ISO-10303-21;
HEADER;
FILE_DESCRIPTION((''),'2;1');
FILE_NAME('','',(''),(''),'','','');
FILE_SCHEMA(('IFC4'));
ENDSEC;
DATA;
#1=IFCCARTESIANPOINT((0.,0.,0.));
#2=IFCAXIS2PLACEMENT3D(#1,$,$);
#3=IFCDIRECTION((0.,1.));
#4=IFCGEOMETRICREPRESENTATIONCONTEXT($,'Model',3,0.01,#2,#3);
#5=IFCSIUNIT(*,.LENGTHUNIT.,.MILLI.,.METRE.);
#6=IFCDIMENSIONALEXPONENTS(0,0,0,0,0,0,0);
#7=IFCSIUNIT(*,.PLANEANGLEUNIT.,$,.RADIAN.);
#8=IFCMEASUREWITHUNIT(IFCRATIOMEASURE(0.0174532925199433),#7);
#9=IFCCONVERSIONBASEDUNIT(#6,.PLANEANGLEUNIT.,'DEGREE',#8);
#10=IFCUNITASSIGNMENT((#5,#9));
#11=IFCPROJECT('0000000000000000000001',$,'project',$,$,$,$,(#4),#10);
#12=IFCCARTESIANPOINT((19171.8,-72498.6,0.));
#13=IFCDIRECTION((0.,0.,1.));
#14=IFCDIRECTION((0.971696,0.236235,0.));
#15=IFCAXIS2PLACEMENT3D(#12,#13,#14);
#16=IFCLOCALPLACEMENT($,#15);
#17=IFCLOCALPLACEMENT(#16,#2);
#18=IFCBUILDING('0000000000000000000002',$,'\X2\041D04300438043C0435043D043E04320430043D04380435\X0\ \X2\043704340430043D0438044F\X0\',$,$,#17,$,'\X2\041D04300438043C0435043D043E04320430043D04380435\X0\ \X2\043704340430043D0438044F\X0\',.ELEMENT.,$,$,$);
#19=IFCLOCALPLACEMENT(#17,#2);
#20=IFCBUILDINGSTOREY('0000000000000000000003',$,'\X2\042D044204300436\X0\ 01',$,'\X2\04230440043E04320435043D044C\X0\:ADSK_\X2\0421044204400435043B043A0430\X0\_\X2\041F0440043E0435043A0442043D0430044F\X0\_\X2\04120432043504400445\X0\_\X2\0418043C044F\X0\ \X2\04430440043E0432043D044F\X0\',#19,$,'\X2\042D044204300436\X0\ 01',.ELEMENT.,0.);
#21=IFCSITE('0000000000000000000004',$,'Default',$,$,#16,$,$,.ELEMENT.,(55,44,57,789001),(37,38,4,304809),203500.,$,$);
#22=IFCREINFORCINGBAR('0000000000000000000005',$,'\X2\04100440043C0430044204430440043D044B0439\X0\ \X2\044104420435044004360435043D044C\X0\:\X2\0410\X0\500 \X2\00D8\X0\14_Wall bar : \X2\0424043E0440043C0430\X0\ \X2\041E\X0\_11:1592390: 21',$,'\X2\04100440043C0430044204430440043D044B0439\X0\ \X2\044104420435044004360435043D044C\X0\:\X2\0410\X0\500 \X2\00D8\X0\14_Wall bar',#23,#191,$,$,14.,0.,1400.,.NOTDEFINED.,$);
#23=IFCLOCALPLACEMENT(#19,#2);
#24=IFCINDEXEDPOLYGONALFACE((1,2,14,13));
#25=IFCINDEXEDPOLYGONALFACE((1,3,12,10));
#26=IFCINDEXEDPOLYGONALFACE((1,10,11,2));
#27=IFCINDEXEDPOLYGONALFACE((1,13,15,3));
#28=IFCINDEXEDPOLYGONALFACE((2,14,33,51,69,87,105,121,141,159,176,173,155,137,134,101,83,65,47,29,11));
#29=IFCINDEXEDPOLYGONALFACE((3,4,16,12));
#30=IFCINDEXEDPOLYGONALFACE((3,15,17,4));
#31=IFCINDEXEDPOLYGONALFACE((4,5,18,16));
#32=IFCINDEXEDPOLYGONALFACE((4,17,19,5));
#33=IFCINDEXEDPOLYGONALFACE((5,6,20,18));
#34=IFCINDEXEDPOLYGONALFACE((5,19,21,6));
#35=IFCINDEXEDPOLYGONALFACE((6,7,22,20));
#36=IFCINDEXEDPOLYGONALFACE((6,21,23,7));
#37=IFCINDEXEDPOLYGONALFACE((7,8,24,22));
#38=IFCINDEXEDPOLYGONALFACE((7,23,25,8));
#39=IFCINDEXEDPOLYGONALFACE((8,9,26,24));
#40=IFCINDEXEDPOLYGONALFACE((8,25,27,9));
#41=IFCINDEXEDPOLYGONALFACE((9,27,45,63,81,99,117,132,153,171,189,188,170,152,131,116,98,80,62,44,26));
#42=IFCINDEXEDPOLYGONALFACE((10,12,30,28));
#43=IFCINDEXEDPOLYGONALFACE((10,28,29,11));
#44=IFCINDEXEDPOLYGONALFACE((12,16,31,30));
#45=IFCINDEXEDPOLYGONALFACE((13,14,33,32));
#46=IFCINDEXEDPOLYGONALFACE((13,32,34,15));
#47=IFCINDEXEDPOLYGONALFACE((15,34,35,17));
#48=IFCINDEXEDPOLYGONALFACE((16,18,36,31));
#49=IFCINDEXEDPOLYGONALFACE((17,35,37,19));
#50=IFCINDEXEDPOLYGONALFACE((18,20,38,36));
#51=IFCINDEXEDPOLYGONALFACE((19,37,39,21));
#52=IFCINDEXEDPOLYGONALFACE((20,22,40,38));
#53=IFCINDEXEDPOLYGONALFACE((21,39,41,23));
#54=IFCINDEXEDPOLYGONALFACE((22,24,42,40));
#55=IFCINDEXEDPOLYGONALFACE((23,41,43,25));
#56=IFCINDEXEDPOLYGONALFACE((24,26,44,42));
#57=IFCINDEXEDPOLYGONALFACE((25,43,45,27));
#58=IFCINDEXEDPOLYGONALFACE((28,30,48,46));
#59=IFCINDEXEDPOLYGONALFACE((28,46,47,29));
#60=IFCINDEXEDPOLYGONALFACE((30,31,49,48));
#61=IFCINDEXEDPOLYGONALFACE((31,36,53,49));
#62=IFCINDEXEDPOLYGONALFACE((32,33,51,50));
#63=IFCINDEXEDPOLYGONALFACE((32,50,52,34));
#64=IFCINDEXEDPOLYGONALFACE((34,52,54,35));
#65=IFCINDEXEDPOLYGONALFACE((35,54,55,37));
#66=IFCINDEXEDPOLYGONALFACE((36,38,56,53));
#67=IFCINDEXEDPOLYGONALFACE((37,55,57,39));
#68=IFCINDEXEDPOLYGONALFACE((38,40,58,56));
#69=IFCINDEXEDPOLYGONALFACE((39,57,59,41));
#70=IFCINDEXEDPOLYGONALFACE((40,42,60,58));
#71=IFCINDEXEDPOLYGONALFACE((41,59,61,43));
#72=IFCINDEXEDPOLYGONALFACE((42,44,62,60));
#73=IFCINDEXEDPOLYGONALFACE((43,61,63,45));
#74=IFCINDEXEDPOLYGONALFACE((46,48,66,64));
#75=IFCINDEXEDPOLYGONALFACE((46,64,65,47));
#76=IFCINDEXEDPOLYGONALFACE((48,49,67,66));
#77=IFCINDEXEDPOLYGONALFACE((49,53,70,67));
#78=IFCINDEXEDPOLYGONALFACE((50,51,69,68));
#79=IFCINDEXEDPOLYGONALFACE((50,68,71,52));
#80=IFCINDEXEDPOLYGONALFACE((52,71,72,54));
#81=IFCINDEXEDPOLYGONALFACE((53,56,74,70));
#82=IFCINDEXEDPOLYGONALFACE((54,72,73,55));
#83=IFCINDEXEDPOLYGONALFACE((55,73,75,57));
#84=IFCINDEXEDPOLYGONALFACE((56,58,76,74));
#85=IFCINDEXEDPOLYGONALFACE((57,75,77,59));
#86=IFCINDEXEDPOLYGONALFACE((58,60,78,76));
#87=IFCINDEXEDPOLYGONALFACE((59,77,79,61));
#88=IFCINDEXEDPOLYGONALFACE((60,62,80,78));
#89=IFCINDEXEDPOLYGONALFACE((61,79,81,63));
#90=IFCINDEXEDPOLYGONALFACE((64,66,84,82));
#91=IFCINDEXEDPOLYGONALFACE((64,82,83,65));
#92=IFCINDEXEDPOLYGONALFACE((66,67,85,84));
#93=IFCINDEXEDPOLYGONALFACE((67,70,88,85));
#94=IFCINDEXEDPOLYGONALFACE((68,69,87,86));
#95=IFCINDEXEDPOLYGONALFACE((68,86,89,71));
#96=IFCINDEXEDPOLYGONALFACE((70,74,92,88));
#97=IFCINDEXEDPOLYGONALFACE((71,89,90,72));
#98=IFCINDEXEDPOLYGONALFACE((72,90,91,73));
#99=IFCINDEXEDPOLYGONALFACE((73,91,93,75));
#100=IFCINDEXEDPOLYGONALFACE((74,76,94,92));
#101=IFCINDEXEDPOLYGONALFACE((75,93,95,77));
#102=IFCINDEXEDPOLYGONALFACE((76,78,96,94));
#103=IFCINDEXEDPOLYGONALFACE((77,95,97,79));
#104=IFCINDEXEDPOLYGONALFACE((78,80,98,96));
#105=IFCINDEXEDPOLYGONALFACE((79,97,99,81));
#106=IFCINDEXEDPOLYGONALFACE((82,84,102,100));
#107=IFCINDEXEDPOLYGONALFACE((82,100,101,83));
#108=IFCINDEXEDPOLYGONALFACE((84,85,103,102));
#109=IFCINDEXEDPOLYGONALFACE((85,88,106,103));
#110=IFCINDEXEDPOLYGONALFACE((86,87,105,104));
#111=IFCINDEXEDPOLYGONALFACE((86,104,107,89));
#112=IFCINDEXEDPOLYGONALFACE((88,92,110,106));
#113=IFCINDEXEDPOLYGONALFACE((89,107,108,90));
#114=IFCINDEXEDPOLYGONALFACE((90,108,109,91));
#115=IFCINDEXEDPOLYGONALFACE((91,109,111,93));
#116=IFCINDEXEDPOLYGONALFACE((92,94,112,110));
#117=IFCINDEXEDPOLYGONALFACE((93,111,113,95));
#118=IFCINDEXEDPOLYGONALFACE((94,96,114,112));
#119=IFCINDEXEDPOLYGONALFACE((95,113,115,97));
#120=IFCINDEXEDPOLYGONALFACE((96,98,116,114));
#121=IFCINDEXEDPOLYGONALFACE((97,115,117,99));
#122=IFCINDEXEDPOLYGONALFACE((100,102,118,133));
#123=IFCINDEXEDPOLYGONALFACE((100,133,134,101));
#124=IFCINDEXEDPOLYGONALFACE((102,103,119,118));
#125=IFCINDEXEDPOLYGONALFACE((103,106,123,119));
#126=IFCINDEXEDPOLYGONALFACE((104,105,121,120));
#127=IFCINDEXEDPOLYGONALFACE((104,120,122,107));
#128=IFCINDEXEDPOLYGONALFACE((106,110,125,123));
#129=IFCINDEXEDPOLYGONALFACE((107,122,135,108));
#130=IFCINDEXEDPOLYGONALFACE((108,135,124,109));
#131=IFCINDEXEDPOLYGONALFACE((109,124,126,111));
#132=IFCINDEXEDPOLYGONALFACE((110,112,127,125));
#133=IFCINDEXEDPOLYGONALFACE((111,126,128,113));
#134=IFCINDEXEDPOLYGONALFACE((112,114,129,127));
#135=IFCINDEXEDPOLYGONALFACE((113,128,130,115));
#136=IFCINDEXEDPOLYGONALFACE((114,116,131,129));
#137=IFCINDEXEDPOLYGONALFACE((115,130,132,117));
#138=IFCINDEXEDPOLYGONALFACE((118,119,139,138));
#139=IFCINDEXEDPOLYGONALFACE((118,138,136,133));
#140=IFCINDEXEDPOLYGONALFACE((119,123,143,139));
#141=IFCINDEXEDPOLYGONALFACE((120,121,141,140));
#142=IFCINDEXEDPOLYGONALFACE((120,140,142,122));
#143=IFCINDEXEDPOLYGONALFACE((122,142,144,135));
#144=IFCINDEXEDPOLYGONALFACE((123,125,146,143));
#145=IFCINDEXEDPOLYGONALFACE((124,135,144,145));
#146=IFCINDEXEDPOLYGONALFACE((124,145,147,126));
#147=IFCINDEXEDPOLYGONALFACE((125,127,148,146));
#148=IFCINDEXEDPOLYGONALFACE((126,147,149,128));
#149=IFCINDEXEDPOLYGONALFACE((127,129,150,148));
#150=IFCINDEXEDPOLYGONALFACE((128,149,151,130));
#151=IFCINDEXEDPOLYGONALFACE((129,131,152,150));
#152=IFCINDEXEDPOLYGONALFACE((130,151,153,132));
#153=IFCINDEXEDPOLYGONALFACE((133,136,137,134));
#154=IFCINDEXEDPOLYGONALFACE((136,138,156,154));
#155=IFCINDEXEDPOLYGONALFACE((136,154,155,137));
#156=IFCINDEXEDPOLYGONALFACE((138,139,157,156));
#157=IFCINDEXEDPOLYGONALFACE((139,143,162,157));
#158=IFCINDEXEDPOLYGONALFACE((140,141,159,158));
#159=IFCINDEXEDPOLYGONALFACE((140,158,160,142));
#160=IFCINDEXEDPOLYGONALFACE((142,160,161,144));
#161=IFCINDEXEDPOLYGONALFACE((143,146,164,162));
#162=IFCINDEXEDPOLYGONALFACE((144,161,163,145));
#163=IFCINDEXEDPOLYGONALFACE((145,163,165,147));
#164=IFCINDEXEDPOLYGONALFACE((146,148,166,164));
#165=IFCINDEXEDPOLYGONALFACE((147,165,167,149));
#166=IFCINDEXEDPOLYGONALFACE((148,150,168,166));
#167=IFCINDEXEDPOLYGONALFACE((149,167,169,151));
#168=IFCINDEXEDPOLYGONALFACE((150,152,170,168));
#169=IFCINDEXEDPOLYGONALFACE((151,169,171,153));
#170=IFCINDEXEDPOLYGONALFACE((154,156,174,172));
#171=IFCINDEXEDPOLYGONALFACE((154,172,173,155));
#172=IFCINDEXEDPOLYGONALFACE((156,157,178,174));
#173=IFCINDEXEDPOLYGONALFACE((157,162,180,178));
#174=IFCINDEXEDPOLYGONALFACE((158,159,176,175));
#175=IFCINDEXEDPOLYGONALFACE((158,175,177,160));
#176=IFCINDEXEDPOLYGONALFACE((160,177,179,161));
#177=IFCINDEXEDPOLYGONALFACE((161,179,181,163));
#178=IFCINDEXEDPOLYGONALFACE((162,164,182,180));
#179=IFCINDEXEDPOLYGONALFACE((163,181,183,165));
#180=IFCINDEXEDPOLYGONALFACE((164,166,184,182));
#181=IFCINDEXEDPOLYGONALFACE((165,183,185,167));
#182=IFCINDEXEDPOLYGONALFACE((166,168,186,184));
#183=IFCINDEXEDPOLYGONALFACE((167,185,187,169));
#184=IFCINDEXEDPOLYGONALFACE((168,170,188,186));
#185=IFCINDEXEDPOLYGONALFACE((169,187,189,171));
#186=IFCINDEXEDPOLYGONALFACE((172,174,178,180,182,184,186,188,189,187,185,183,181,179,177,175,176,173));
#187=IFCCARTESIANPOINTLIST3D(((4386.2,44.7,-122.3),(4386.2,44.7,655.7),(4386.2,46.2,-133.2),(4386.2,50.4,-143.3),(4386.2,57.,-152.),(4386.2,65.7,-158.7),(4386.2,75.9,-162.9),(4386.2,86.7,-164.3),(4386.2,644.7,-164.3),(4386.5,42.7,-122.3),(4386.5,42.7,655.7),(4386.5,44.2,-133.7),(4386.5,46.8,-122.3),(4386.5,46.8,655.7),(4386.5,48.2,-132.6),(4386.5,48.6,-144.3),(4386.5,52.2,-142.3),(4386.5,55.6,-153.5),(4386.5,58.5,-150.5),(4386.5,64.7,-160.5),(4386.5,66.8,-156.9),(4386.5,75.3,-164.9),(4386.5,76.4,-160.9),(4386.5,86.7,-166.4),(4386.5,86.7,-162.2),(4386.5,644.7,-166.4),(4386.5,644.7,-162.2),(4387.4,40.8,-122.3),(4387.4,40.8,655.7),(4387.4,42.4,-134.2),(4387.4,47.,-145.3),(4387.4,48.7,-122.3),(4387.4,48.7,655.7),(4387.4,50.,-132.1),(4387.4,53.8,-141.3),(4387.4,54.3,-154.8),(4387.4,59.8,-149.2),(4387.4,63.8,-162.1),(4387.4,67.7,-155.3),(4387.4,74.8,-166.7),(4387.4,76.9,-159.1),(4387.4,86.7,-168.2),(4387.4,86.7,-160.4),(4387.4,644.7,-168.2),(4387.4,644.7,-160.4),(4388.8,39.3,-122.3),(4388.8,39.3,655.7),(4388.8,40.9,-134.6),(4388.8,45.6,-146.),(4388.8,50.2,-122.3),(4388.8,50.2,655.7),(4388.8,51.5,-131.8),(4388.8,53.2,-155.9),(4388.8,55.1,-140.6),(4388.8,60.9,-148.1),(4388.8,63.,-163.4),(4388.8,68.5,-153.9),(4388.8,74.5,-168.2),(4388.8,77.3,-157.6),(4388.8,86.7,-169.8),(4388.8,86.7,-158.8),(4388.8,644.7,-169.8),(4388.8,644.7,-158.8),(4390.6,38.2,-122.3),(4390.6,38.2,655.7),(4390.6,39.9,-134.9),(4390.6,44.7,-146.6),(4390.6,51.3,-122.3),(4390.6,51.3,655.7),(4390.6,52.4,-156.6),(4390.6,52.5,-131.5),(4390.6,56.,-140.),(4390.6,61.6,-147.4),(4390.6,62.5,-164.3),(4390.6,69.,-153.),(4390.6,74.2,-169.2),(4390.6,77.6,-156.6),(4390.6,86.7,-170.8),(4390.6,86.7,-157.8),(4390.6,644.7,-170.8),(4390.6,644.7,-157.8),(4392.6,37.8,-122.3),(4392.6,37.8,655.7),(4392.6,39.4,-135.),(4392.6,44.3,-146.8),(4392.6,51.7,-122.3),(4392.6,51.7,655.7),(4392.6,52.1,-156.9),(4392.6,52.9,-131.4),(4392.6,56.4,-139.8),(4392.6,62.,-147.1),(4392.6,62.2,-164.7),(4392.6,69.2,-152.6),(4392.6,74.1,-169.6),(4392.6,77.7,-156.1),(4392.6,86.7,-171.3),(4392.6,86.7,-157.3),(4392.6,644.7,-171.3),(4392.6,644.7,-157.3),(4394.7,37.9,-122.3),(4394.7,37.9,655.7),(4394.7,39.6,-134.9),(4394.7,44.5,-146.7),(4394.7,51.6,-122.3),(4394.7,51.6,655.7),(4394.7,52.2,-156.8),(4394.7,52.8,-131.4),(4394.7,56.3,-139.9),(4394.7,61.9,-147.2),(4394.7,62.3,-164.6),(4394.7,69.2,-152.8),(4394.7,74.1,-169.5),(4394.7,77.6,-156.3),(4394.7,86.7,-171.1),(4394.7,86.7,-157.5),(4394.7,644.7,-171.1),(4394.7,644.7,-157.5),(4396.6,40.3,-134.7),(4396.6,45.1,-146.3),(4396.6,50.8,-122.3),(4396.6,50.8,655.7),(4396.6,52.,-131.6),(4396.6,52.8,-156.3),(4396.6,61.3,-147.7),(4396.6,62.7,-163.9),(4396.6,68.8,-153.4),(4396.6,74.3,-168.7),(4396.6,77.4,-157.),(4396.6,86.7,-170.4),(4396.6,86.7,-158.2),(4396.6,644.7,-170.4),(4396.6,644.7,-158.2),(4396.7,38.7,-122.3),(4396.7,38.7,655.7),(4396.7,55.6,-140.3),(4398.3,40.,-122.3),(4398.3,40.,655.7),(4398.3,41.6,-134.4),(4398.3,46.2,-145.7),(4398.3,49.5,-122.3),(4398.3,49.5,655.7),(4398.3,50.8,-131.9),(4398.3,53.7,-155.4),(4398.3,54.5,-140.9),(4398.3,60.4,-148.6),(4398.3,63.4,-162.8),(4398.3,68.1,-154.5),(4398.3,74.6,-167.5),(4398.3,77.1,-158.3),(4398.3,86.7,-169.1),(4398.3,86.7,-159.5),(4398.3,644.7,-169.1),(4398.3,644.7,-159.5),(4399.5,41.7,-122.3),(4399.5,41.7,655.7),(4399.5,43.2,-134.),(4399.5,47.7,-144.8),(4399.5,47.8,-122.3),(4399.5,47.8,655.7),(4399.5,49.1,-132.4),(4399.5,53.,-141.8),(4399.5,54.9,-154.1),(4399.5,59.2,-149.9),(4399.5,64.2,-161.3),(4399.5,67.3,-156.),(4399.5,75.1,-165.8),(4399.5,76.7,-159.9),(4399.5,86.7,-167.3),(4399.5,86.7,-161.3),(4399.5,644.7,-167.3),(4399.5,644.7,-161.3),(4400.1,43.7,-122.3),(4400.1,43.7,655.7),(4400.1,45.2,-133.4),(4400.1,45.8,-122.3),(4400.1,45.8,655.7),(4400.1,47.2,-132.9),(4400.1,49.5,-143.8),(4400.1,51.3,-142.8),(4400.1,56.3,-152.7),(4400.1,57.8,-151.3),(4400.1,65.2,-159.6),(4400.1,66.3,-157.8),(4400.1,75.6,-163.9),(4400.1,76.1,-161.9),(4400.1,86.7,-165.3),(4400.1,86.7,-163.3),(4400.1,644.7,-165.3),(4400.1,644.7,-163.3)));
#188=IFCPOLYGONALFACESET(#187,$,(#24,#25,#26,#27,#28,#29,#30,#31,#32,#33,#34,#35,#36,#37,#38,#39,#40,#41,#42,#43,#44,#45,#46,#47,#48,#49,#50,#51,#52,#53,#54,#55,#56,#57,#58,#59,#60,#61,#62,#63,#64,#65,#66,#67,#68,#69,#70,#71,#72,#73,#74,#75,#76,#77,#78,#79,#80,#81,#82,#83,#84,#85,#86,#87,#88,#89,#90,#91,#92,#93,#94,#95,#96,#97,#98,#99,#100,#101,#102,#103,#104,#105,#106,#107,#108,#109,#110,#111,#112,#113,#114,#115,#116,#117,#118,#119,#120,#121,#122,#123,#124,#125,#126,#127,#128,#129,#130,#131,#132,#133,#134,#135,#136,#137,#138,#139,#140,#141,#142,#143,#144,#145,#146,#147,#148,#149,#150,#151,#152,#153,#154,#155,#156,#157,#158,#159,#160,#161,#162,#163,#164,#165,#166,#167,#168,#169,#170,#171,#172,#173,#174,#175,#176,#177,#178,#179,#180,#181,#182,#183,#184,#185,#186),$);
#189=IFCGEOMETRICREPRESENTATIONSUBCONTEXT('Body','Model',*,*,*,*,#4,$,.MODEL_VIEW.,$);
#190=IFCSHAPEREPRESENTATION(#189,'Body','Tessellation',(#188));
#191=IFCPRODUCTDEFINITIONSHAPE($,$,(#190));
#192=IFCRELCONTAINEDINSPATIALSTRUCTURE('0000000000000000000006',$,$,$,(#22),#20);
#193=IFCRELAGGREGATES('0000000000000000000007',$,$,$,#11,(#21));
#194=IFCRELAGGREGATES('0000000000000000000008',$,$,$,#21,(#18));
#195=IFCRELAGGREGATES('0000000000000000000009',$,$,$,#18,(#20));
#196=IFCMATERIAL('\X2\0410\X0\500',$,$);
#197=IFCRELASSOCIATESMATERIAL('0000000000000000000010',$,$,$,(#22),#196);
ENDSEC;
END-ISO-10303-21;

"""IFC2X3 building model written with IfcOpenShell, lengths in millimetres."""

from ifc_helpers import new_model, entity, si_unit, converted_unit, direction, frame, origin, place, context, subcontext, project, spatial, material, element, save


model = new_model("IFC2X3")

# Units and contexts
model_context = context("Model", 3, precision=0.01, world=origin(), true_north=direction((0.0, 1.0)))
body_context = subcontext(model_context, "Body", "Model", "MODEL_VIEW")
ifc_project = project(units=[si_unit("LENGTHUNIT", "METRE", prefix="MILLI"), converted_unit("PLANEANGLEUNIT", "DEGREE", entity("IfcRatioMeasure", 0.0174532925199433), si_unit("PLANEANGLEUNIT", "RADIAN"), dimensions=[0, 0, 0, 0, 0, 0, 0])], contexts=[model_context])

# Site, building, storey
site_placement = place(None, frame((19171.8, -72498.6, 0.0), z_axis=(0.0, 0.0, 1.0), x_axis=(0.971696, 0.236235, 0.0)))
site = spatial("IfcSite", under=ifc_project, at=site_placement, Name="Default", CompositionType="ELEMENT", RefLatitude=(55, 44, 57, 789001), RefLongitude=(37, 38, 4, 304809), RefElevation=203500.0)
building_placement = place(site_placement, origin())
building = spatial("IfcBuilding", under=site, at=building_placement, Name="Наименование здания", LongName="Наименование здания", CompositionType="ELEMENT")
storey_placement = place(building_placement, origin())
storey = spatial("IfcBuildingStorey", under=building, at=storey_placement, Name="Этаж 01", ObjectType="Уровень:ADSK_Стрелка_Проектная_Вверх_Имя уровня", LongName="Этаж 01", CompositionType="ELEMENT", Elevation=0.0)

# Reinforcing bar
ifc_material = material(Name="А500")
placement = place(storey_placement, origin())
element("IfcReinforcingBar", 1, at=placement, inside=storey, material=ifc_material, Name="Арматурный стержень:А500 Ø14_Wall bar : Форма О_11:1592390: 21", ObjectType="Арматурный стержень:А500 Ø14_Wall bar", BarLength=1400.0, BarRole="NOTDEFINED", CrossSectionArea=0.0, NominalDiameter=14.0, context=body_context, shape_type="AdvancedSweptSolid", body=[
    entity("IfcSweptDiskSolid", entity("IfcCompositeCurve", [entity("IfcCompositeCurveSegment", "CONTINUOUS", True, entity("IfcPolyline", [entity("IfcCartesianPoint", [4393.1, 44.7, 655.7]), entity("IfcCartesianPoint", [4393.1, 44.7, -122.3])])), entity("IfcCompositeCurveSegment", "CONTINUOUS", True, entity("IfcTrimmedCurve", entity("IfcCircle", entity("IfcAxis2Placement3D", entity("IfcCartesianPoint", [4393.1, 86.7, -122.3]), entity("IfcDirection", [1.0, 0.0, 0.0]), entity("IfcDirection", [0.0, 0.0, -1.0])), 42.0), [entity("IfcParameterValue", 270.0)], [entity("IfcParameterValue", 360.0)], True, "PARAMETER")), entity("IfcCompositeCurveSegment", "CONTINUOUS", True, entity("IfcPolyline", [entity("IfcCartesianPoint", [4393.1, 86.7, -164.3]), entity("IfcCartesianPoint", [4393.1, 644.7, -164.3])]))], False), 7.0, None, 0.0, 92.0),
])

save(model, "model.ifc")
